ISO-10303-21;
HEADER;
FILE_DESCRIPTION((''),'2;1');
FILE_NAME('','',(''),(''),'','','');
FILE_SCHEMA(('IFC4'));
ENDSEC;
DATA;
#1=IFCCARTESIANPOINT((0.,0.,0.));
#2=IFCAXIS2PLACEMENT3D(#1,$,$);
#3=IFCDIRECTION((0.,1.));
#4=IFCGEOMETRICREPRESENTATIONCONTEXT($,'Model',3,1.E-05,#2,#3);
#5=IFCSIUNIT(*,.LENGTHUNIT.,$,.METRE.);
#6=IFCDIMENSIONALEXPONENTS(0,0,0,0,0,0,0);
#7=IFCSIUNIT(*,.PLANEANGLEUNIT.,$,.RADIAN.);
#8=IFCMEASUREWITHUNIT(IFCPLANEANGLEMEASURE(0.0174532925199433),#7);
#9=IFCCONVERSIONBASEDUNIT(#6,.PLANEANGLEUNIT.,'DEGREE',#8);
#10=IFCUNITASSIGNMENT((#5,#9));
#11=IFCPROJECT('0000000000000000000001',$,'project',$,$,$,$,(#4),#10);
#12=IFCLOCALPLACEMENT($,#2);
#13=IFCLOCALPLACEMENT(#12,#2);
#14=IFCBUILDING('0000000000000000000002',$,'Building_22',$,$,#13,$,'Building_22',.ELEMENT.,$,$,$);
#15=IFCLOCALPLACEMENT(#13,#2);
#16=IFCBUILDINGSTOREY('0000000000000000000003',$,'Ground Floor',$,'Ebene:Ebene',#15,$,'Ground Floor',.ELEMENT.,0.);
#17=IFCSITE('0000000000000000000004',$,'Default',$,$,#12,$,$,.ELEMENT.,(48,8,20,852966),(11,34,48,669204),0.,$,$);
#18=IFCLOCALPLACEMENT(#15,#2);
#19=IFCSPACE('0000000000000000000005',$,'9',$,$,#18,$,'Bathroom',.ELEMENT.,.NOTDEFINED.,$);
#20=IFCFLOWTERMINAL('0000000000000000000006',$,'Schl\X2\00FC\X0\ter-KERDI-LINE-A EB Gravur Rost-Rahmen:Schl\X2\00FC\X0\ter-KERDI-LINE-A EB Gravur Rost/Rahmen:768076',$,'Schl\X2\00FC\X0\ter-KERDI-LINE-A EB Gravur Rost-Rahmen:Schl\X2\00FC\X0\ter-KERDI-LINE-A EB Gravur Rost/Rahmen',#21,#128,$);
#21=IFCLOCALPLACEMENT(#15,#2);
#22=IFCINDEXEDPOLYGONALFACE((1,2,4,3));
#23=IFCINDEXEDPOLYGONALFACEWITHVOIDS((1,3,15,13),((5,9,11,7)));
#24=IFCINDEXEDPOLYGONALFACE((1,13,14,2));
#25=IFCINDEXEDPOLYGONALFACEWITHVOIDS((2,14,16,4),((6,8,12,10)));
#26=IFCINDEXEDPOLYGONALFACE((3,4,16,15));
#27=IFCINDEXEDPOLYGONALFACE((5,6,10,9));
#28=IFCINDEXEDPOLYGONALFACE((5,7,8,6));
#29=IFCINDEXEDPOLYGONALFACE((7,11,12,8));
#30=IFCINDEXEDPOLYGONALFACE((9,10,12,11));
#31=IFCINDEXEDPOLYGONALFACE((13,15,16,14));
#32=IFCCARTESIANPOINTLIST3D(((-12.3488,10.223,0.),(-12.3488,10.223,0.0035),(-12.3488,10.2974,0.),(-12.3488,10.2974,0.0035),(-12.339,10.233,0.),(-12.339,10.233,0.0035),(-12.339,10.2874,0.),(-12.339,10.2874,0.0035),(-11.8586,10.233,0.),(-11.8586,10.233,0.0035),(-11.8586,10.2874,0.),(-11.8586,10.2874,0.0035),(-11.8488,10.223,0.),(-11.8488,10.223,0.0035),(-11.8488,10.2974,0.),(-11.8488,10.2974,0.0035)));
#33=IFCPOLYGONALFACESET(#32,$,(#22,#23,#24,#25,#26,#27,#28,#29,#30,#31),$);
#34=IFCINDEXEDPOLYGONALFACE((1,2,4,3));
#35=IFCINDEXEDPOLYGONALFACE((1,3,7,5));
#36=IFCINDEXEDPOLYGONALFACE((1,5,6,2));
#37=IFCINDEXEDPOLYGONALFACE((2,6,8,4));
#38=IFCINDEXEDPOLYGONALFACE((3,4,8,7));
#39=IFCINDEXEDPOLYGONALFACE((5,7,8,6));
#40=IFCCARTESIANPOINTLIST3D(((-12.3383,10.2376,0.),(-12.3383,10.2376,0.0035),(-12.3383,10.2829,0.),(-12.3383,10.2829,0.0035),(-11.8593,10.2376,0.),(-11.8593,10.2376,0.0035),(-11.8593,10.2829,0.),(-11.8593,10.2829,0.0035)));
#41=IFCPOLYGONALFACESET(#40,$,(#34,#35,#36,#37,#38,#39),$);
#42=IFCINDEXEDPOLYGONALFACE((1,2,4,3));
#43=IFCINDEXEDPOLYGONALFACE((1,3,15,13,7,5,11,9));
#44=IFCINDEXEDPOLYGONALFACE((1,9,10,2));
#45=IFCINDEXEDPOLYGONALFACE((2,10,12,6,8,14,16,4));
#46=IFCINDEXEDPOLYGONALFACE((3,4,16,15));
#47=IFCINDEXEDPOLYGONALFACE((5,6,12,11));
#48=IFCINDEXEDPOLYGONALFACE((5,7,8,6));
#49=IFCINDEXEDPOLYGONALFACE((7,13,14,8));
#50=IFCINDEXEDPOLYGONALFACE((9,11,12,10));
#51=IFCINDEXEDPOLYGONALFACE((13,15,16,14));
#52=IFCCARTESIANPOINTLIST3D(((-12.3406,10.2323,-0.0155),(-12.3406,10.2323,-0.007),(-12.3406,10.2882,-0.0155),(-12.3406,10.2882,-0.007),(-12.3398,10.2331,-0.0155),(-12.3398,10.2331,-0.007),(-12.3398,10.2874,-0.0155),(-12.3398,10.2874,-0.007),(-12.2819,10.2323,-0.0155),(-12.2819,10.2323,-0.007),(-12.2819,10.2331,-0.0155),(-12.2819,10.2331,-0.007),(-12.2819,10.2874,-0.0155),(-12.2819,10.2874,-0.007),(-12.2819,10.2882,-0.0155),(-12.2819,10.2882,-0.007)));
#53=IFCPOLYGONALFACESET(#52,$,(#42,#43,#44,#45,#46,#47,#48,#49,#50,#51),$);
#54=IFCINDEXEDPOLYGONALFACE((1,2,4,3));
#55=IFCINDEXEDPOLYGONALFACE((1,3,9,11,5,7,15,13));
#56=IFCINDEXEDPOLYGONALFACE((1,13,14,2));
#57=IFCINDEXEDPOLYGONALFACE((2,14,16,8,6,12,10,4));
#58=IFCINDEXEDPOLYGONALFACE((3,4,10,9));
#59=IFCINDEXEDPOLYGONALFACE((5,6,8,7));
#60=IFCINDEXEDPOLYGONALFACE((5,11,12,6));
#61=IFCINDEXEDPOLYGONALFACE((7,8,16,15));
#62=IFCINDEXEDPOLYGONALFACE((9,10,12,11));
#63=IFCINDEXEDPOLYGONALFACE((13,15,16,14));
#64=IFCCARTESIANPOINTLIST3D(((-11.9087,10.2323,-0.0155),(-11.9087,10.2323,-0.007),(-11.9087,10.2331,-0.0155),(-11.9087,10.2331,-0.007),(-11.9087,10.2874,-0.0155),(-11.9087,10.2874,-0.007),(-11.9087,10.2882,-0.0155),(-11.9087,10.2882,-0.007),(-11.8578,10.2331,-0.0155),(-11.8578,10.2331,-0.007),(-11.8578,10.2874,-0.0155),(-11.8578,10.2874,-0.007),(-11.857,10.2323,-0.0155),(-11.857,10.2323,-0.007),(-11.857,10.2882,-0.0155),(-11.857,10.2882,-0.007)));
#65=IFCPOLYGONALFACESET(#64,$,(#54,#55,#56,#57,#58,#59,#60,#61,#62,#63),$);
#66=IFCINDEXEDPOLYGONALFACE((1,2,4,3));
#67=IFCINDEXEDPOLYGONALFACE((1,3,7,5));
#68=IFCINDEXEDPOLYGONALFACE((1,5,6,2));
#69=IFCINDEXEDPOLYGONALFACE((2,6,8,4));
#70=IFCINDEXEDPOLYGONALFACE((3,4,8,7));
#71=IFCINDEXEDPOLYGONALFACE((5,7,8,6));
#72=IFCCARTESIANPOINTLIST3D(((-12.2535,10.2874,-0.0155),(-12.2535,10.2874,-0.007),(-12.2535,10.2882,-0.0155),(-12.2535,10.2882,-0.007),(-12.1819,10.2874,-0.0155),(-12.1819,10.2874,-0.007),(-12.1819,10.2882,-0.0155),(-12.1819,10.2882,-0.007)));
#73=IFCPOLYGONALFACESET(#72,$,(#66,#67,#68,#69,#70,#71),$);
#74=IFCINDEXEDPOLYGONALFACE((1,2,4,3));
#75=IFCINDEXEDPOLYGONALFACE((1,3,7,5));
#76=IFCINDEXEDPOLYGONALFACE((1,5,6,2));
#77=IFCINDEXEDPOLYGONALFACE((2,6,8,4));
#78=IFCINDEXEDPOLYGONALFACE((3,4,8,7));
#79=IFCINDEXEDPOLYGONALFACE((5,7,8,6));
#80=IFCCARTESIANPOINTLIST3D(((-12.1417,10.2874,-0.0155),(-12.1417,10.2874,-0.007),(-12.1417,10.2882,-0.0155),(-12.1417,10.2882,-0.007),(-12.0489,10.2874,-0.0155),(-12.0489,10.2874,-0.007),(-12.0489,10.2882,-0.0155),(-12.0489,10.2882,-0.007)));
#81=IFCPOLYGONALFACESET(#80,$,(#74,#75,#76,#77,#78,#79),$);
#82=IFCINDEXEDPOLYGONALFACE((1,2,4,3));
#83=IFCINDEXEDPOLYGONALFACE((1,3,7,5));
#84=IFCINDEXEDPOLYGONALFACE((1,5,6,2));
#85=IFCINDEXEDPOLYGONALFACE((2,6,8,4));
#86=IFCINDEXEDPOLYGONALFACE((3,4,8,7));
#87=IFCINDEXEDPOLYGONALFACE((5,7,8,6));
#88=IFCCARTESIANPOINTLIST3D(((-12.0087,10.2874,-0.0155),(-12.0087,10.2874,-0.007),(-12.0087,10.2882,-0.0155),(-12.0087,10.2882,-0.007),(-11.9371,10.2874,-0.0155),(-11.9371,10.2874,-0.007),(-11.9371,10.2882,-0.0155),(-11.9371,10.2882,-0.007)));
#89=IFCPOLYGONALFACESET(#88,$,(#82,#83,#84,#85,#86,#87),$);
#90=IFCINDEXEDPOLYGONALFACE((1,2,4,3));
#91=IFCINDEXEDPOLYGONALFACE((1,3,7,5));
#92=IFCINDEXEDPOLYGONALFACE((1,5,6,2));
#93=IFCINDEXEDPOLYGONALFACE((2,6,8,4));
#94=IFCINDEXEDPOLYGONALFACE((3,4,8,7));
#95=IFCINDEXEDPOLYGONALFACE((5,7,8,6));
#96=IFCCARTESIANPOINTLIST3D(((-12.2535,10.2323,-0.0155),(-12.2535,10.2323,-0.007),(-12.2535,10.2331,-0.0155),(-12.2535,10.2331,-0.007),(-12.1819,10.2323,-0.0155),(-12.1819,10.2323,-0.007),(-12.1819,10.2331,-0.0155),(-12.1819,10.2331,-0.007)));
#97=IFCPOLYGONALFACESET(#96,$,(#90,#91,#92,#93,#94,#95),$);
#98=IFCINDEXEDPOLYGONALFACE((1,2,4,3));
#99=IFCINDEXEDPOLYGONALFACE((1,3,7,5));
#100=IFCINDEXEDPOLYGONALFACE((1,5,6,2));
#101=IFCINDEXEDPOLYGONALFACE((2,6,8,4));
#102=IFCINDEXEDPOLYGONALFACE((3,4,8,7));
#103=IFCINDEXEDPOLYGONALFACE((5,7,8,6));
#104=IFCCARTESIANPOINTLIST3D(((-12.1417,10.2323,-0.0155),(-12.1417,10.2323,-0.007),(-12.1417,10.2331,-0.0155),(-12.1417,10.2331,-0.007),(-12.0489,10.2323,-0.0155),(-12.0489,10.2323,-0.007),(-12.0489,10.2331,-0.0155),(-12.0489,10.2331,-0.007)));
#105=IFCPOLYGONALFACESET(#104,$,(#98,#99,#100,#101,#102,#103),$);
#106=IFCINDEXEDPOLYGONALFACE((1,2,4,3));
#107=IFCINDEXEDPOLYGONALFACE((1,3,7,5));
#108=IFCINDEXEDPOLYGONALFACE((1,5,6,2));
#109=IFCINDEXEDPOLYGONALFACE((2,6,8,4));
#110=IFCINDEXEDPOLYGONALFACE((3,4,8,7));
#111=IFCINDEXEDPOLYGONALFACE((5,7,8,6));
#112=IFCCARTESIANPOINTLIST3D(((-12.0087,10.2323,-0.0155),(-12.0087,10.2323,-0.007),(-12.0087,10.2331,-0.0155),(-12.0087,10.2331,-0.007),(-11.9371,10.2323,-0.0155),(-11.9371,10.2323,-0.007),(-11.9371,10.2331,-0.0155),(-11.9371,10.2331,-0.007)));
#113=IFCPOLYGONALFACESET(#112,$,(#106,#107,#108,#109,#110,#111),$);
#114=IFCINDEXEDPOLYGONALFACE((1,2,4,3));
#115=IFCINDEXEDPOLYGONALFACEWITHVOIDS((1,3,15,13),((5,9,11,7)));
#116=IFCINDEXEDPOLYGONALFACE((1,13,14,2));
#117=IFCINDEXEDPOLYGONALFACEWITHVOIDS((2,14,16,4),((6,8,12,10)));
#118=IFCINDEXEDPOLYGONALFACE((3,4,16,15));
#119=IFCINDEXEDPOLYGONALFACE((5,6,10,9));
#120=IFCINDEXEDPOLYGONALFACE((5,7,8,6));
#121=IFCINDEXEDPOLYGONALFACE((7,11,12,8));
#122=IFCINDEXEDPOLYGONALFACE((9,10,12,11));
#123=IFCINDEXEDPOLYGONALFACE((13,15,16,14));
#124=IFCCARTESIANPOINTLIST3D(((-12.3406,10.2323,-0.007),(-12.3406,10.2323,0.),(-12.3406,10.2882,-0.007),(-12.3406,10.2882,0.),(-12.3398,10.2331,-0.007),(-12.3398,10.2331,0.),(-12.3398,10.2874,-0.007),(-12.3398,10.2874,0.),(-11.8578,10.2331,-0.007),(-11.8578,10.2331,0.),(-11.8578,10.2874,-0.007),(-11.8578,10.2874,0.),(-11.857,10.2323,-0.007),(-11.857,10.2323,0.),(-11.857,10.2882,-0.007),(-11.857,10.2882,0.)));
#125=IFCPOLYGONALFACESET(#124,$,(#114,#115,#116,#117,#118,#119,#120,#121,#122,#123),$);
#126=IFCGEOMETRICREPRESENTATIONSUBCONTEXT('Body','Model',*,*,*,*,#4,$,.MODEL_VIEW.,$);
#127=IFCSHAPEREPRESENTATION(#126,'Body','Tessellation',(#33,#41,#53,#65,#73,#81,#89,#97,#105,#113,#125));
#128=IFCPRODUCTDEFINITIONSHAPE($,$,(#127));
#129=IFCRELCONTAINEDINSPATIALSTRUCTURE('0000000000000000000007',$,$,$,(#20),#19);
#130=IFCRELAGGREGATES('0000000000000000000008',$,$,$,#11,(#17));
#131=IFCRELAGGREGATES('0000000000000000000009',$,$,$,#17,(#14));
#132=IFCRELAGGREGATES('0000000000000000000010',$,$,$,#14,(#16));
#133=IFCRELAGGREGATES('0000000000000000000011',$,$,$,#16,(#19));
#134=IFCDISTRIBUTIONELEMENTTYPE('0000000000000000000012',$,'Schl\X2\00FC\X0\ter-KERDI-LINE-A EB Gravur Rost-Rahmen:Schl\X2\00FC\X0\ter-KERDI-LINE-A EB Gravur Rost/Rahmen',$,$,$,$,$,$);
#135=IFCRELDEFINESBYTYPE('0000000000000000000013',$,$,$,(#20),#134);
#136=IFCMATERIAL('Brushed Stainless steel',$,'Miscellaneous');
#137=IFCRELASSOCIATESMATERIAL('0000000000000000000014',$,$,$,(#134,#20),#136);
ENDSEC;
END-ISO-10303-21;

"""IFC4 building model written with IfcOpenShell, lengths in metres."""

from ifc_helpers import new_model, entity, si_unit, converted_unit, direction, frame, origin, place, context, subcontext, project, spatial, indexed_curve, outline, extrude, source, transform, mapped, material, type_object, type_shapes, element, save


model = new_model("IFC4")

# Units and contexts
model_context = context("Model", 3, precision=1e-05, world=origin(), true_north=direction((0.0, 1.0)))
body_context = subcontext(model_context, "Body", "Model", "MODEL_VIEW")
ifc_project = project(units=[si_unit("LENGTHUNIT", "METRE"), converted_unit("PLANEANGLEUNIT", "DEGREE", entity("IfcPlaneAngleMeasure", 0.0174532925199433), si_unit("PLANEANGLEUNIT", "RADIAN"), dimensions=[0, 0, 0, 0, 0, 0, 0])], contexts=[model_context])

# Site, building, storey
site_placement = place(None, origin())
site = spatial("IfcSite", under=ifc_project, at=site_placement, Name="Default", CompositionType="ELEMENT", RefLatitude=(48, 8, 20, 852966), RefLongitude=(11, 34, 48, 669204), RefElevation=0.0)
building_placement = place(site_placement, origin())
building = spatial("IfcBuilding", under=site, at=building_placement, Name="Building_22", LongName="Building_22", CompositionType="ELEMENT")
storey_placement = place(building_placement, origin())
storey = spatial("IfcBuildingStorey", under=building, at=storey_placement, Name="Ground Floor", ObjectType="Ebene:Ebene", LongName="Ground Floor", CompositionType="ELEMENT", Elevation=0.0)

# Shared definitions
space_1_placement = place(storey_placement, origin())
space_1 = spatial("IfcSpace", under=storey, at=space_1_placement, Name="9", LongName="Bathroom", CompositionType="ELEMENT", PredefinedType="NOTDEFINED")

# Flow terminal
ifc_material_1 = material(Name="Brushed Stainless steel", Category="Miscellaneous")
distribution_element_type_1 = type_object("IfcDistributionElementType", Name="Schlüter-KERDI-LINE-A EB Gravur Rost-Rahmen:Schlüter-KERDI-LINE-A EB Gravur Rost/Rahmen", material=ifc_material_1)
shared_shape_1 = source(origin(), body_context, "Body", "SweptSolid", [
    extrude(outline(indexed_curve([(-0.25, -0.0372), (0.25, -0.0372), (0.25, 0.0372), (-0.25, 0.0372), (-0.25, -0.0372)], self_intersect=False), holes=[indexed_curve([(0.2402, 0.0272), (0.2402, -0.0272), (-0.2402, -0.0272), (-0.2402, 0.0272), (0.2402, 0.0272)], self_intersect=False)]), frame((0.0, 0.0, 0.0), z_axis=(0.0, 0.0, 1.0), x_axis=(-1.0, 0.0, 0.0)), (0.0, 0.0, 1.0), 0.0035),
    extrude(outline(indexed_curve([(-0.2395, -0.0227), (0.2395, -0.0227), (0.2395, 0.0227), (-0.2395, 0.0227), (-0.2395, -0.0227)], self_intersect=False)), frame((0.0, 0.0, 0.0), z_axis=(0.0, 0.0, 1.0), x_axis=(-1.0, 0.0, 0.0)), (0.0, 0.0, 1.0), 0.0035),
    extrude(outline(indexed_curve([(-0.0291, -0.028), (0.0295, -0.028), (0.0295, 0.028), (-0.0291, 0.028), (-0.0291, 0.0272), (0.0287, 0.0272), (0.0287, -0.0272), (-0.0291, -0.0272), (-0.0291, -0.028)], self_intersect=False)), frame((-0.2123, 0.0, -0.0155), z_axis=(0.0, 0.0, 1.0), x_axis=(-1.0, 0.0, 0.0)), (0.0, 0.0, 1.0), 0.0085),
    extrude(outline(indexed_curve([(-0.0272, -0.0252), (-0.0272, 0.0256), (-0.028, 0.0256), (-0.028, -0.026), (0.028, -0.026), (0.028, 0.0256), (0.0272, 0.0256), (0.0272, -0.0252), (-0.0272, -0.0252)], self_intersect=False)), frame((0.2158, 0.0, -0.0155), z_axis=(0.0, 0.0, -1.0), x_axis=(0.0, -1.0, 0.0)), (0.0, 0.0, -1.0), 0.0085),
    extrude(outline(indexed_curve([(-0.0358, -0.0004), (0.0358, -0.0004), (0.0358, 0.0004), (-0.0358, 0.0004), (-0.0358, -0.0004)], self_intersect=False)), frame((-0.1189, 0.0276, -0.0155)), (0.0, 0.0, 1.0), 0.0085),
    extrude(outline(indexed_curve([(-0.0464, -0.0004), (0.0464, -0.0004), (0.0464, 0.0004), (-0.0464, 0.0004), (-0.0464, -0.0004)], self_intersect=False)), frame((0.0035, 0.0276, -0.0155)), (0.0, 0.0, 1.0), 0.0085),
    extrude(outline(indexed_curve([(-0.0358, -0.0004), (0.0358, -0.0004), (0.0358, 0.0004), (-0.0358, 0.0004), (-0.0358, -0.0004)], self_intersect=False)), frame((0.1259, 0.0276, -0.0155)), (0.0, 0.0, 1.0), 0.0085),
    extrude(outline(indexed_curve([(-0.0004, -0.0358), (0.0004, -0.0358), (0.0004, 0.0358), (-0.0004, 0.0358), (-0.0004, -0.0358)], self_intersect=False)), frame((-0.1189, -0.0276, -0.0155), z_axis=(0.0, 0.0, 1.0), x_axis=(0.0, -1.0, 0.0)), (0.0, 0.0, 1.0), 0.0085),
    extrude(outline(indexed_curve([(-0.0004, -0.0464), (0.0004, -0.0464), (0.0004, 0.0464), (-0.0004, 0.0464), (-0.0004, -0.0464)], self_intersect=False)), frame((0.0035, -0.0276, -0.0155), z_axis=(0.0, 0.0, 1.0), x_axis=(0.0, -1.0, 0.0)), (0.0, 0.0, 1.0), 0.0085),
    extrude(outline(indexed_curve([(-0.0004, -0.0358), (0.0004, -0.0358), (0.0004, 0.0358), (-0.0004, 0.0358), (-0.0004, -0.0358)], self_intersect=False)), frame((0.1259, -0.0276, -0.0155), z_axis=(0.0, 0.0, 1.0), x_axis=(0.0, -1.0, 0.0)), (0.0, 0.0, 1.0), 0.0085),
    extrude(outline(indexed_curve([(-0.2418, -0.028), (0.2418, -0.028), (0.2418, 0.028), (-0.2418, 0.028), (-0.2418, -0.028)], self_intersect=False), holes=[indexed_curve([(0.241, -0.0272), (-0.241, -0.0272), (-0.241, 0.0272), (0.241, 0.0272), (0.241, -0.0272)], self_intersect=False)]), frame((0.0, 0.0, -0.007), z_axis=(0.0, 0.0, 1.0), x_axis=(-1.0, 0.0, 0.0)), (0.0, 0.0, 1.0), 0.007),
])
type_shapes(distribution_element_type_1, [shared_shape_1])
flow_terminal_1_placement = place(space_1_placement, frame((-12.0988, 10.2602, 0.0)))
element("IfcFlowTerminal", 1, at=flow_terminal_1_placement, inside=space_1, type_object=distribution_element_type_1, material=ifc_material_1, Name="Schlüter-KERDI-LINE-A EB Gravur Rost-Rahmen:Schlüter-KERDI-LINE-A EB Gravur Rost/Rahmen:768076", ObjectType="Schlüter-KERDI-LINE-A EB Gravur Rost-Rahmen:Schlüter-KERDI-LINE-A EB Gravur Rost/Rahmen", context=body_context, shape_type="MappedRepresentation", body=[
    mapped(shared_shape_1, transform((0.0, 0.0, 0.0), scale=1.0)),
])

save(model, "model.ifc")
